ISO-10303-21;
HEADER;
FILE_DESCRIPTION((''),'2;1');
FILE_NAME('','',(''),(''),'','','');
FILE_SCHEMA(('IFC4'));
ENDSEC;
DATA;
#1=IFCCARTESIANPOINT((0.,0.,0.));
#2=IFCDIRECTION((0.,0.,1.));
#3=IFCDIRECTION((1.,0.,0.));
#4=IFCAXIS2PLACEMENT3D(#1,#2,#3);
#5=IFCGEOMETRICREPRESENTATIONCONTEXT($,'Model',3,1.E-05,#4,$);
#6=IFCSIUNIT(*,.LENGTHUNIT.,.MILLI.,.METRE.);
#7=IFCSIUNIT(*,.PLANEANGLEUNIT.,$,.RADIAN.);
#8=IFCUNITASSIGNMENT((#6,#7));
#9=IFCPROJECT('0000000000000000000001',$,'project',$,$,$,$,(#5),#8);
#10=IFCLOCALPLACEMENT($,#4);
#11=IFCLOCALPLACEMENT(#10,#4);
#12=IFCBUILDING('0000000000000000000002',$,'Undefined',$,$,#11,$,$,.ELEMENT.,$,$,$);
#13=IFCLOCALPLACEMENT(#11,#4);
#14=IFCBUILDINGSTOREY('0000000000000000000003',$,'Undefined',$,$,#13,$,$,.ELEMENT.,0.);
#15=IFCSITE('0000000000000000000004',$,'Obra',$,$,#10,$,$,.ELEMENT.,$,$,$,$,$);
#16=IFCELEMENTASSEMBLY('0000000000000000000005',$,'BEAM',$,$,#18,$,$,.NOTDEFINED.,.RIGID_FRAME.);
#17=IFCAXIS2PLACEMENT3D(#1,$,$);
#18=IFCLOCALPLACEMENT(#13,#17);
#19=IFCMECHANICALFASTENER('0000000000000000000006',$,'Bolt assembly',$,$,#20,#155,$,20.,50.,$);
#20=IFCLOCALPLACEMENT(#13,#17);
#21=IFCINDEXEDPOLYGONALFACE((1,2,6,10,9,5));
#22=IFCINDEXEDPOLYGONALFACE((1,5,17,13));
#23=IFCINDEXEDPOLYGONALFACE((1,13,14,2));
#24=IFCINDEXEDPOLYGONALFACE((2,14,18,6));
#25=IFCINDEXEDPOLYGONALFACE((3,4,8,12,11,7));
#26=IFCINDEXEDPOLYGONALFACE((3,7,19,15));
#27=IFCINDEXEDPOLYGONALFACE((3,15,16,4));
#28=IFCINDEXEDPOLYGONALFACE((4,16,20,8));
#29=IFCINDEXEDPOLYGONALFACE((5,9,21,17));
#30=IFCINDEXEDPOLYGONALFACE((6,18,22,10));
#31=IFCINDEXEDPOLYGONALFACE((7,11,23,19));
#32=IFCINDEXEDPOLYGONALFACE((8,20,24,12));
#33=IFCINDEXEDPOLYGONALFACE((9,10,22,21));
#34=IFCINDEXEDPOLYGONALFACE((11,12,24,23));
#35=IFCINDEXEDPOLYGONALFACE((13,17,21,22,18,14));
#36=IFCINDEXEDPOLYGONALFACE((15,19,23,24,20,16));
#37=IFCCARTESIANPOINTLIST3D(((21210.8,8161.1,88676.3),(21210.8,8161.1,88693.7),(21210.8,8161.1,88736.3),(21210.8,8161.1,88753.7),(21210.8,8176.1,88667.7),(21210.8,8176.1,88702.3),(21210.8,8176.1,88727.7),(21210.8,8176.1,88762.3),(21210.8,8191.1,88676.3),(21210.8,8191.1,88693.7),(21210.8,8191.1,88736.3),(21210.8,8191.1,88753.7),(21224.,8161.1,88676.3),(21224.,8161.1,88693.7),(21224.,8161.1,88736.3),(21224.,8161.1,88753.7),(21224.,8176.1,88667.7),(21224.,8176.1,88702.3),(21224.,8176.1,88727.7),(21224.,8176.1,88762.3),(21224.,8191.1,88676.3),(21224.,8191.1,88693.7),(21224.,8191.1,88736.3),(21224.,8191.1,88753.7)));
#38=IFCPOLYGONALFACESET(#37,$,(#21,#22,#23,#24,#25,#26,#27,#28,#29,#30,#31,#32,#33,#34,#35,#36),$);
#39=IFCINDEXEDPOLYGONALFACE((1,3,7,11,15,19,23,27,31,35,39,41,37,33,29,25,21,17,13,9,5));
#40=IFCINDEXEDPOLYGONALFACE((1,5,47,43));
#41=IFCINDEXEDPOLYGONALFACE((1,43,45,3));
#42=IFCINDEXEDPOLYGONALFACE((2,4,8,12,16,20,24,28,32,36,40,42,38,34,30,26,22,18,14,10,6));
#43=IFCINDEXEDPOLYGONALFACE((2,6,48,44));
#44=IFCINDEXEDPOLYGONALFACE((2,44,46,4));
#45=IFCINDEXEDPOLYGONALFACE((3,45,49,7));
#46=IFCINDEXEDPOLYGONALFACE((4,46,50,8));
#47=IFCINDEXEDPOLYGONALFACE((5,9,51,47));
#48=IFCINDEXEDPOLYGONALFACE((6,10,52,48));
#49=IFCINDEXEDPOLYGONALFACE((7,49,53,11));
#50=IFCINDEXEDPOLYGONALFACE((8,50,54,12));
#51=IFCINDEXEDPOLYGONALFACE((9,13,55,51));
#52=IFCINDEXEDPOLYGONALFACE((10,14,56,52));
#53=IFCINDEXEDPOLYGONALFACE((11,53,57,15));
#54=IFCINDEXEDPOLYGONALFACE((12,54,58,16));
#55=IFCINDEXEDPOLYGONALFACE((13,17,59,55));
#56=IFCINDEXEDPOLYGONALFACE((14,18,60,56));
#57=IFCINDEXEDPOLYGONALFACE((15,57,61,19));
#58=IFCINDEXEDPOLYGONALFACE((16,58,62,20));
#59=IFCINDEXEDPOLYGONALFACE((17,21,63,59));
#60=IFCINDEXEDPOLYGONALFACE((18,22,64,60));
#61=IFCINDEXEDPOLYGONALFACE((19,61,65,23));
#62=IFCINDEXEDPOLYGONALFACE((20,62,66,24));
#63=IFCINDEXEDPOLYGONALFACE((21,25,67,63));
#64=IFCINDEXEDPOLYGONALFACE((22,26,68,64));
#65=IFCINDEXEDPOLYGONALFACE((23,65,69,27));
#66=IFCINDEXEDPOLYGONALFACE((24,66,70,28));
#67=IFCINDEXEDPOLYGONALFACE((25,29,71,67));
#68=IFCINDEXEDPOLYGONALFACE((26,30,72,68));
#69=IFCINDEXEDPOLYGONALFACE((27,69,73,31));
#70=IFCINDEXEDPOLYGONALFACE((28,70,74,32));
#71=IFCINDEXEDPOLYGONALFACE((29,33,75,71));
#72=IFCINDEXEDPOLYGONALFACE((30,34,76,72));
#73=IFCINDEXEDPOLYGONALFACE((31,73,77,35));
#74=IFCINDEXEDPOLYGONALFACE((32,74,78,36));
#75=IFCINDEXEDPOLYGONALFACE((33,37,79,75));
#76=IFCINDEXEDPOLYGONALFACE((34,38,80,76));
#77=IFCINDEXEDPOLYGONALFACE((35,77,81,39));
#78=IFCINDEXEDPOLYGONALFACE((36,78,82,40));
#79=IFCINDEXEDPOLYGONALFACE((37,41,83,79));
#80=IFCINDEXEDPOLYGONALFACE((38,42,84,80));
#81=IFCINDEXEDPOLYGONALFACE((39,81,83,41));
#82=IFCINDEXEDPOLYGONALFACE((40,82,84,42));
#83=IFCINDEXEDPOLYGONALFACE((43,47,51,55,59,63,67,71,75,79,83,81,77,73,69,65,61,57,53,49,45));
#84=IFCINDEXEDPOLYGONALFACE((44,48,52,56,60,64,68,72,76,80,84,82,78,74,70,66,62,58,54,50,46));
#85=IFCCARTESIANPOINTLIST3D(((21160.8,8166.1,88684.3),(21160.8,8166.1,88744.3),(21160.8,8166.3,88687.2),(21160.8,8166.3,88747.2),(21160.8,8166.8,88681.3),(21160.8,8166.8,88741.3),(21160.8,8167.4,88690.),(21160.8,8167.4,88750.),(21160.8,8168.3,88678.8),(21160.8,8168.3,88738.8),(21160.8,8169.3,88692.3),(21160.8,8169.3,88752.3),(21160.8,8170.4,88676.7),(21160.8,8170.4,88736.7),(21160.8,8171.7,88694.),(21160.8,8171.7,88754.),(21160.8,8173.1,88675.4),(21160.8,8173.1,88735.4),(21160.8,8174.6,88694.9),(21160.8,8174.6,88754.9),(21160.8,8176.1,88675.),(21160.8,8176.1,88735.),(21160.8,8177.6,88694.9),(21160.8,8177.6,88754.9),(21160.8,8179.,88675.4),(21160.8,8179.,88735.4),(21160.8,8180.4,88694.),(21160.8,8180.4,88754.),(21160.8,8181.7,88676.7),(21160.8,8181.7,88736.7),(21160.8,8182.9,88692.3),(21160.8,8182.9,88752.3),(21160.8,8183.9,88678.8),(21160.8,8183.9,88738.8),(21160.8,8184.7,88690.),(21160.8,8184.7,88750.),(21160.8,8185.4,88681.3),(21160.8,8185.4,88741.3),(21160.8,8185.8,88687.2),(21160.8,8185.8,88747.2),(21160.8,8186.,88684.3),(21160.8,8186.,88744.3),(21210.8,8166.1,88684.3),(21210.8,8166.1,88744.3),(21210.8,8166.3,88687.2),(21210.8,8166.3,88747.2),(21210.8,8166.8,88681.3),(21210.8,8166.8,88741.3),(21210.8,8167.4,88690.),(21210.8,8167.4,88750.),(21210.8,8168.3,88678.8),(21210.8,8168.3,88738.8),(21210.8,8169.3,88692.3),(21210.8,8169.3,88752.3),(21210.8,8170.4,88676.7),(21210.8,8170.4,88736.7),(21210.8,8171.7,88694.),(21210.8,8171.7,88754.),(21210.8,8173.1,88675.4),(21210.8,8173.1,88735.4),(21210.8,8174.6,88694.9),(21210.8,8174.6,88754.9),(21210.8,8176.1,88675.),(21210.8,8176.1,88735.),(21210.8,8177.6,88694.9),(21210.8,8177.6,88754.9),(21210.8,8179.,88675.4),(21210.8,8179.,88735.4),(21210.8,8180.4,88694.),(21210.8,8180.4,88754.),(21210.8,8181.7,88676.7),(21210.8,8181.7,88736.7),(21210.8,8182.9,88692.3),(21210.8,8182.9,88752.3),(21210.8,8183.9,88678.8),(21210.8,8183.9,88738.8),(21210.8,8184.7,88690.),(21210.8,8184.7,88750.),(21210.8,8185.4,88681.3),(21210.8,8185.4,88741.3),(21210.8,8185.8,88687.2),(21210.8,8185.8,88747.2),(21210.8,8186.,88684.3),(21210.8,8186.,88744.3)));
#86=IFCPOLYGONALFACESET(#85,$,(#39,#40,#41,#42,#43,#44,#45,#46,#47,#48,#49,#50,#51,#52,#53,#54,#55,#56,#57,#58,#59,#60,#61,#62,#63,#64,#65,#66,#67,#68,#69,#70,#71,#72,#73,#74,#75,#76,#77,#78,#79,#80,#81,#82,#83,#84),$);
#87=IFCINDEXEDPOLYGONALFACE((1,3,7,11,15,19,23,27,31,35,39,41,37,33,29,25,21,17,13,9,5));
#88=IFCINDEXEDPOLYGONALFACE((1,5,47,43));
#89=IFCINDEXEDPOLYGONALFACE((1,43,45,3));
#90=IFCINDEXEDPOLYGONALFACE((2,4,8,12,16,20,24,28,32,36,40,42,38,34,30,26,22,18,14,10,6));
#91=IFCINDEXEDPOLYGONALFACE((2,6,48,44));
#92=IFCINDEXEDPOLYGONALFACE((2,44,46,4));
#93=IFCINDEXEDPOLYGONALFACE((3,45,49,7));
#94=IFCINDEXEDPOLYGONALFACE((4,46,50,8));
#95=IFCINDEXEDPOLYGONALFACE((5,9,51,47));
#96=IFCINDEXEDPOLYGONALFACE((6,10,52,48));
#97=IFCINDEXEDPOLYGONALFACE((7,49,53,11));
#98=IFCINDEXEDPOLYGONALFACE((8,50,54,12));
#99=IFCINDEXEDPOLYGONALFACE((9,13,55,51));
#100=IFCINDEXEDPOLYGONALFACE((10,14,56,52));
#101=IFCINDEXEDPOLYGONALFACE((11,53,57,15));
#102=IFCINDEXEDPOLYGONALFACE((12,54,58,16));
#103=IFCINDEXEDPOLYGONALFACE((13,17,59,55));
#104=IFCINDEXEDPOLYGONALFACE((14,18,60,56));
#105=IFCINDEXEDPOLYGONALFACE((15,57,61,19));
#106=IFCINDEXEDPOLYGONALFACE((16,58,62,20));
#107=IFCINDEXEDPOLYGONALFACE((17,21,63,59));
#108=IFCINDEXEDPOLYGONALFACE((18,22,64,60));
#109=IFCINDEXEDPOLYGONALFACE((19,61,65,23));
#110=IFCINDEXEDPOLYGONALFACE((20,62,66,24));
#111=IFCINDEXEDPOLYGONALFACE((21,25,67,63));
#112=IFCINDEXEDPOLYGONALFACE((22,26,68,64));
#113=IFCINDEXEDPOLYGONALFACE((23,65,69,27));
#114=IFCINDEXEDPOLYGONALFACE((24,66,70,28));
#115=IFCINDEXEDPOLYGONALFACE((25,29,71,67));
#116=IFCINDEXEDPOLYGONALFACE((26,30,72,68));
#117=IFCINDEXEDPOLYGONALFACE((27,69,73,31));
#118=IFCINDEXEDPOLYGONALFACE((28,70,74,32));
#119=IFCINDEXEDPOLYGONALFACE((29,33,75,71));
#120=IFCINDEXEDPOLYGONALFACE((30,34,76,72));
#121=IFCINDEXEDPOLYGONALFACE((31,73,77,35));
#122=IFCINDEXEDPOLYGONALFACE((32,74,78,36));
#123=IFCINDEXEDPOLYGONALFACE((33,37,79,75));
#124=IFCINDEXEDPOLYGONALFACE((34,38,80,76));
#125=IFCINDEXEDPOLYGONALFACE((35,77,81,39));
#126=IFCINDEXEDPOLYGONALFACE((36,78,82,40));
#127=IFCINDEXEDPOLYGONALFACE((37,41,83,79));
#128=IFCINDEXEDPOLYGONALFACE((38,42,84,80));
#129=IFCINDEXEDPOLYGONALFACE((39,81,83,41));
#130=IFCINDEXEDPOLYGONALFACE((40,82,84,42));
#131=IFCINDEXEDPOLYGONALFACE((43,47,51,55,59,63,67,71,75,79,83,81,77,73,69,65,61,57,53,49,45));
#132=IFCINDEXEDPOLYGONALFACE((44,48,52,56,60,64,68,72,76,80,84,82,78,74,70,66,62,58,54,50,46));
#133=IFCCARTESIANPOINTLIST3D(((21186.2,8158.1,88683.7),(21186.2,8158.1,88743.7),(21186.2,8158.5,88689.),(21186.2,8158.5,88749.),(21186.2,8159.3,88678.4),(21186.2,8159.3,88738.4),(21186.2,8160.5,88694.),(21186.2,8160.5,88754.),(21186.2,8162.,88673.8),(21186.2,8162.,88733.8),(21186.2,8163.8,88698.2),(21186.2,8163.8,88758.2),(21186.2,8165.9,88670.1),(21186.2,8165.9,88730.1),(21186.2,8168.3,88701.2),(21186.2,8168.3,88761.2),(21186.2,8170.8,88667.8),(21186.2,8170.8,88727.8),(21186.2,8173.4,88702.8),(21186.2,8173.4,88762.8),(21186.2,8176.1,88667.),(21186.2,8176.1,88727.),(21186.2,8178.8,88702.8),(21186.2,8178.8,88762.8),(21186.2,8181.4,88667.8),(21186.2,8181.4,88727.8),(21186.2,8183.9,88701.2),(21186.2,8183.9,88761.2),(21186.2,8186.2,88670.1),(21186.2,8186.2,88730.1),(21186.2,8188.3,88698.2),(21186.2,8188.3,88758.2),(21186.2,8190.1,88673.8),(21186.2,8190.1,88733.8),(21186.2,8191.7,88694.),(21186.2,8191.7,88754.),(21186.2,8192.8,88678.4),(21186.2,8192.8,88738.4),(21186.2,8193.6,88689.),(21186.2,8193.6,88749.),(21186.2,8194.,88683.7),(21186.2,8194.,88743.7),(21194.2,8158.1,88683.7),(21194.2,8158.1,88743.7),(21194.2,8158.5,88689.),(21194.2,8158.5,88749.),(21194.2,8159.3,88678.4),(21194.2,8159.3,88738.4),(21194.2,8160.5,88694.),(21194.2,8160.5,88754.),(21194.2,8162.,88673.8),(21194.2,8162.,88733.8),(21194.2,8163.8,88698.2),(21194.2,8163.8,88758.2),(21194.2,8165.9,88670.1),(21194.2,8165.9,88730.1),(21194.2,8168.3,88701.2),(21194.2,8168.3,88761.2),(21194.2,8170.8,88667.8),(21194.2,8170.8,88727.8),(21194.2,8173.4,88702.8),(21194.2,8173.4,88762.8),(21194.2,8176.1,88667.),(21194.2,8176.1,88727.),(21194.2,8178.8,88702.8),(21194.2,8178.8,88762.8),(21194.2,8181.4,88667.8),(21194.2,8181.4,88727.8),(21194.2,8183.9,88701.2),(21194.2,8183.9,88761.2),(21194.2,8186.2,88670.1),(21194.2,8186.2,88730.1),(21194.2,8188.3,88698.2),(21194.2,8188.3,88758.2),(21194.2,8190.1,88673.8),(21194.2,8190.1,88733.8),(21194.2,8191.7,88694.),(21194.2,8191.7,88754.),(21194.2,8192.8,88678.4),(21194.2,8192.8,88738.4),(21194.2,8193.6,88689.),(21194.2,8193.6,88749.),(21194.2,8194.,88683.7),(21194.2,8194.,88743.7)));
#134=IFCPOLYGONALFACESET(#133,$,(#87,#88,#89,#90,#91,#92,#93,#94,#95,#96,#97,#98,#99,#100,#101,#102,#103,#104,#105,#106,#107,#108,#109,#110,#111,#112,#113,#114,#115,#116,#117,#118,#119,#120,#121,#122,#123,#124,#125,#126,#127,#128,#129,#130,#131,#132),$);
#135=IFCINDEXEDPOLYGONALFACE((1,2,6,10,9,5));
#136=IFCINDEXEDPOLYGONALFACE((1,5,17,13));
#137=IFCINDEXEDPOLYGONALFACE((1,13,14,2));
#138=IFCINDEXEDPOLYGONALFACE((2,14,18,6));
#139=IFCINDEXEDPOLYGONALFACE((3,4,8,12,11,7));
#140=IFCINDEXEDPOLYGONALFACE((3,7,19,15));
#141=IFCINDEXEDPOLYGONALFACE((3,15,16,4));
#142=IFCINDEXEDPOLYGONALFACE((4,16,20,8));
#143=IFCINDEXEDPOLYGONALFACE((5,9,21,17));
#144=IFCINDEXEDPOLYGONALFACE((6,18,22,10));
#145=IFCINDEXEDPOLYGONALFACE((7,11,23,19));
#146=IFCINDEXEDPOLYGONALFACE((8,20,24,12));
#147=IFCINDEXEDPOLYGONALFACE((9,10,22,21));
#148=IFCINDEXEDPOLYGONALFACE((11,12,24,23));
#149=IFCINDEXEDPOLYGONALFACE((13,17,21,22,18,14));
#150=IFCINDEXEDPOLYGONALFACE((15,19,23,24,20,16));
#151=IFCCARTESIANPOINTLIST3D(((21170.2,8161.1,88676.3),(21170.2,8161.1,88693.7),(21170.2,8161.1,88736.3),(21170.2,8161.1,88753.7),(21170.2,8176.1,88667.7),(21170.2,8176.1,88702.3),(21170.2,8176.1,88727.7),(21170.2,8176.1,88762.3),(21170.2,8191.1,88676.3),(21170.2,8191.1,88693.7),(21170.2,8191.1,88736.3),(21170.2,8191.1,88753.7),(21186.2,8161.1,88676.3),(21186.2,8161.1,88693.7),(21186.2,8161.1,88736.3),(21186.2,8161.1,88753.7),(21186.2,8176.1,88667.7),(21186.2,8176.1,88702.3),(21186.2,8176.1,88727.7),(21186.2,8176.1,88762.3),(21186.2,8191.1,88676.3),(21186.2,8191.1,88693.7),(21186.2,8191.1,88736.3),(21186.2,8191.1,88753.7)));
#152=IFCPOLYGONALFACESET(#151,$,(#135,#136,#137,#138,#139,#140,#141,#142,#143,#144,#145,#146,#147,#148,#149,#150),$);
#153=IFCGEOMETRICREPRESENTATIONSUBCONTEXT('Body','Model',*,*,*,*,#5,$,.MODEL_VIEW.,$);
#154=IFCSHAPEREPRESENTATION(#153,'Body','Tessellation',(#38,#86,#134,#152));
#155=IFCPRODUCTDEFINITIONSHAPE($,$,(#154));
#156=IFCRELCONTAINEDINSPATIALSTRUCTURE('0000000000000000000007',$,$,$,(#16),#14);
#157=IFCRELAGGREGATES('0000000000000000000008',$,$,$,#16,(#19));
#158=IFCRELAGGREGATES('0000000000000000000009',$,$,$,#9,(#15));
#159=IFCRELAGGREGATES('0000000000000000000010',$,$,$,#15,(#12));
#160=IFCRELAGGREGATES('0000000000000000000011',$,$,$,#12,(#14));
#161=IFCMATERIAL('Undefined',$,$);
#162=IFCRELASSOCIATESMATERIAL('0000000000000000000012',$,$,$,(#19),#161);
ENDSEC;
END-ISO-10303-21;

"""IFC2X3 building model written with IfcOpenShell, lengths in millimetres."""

from ifc_helpers import new_model, si_unit, frame, origin_with_axes, origin_2d_with_axis, place, context, subcontext, project, spatial, polyline, circle, outline, extrude, source, transform, mapped, material, element, aggregate, save


model = new_model("IFC2X3")

# Units and contexts
model_context = context("Model", 3, precision=1e-05, world=origin_with_axes())
body_context = subcontext(model_context, "Body", "Model", "MODEL_VIEW")
ifc_project = project(units=[si_unit("LENGTHUNIT", "METRE", prefix="MILLI"), si_unit("PLANEANGLEUNIT", "RADIAN")], contexts=[model_context])

# Site, building, storey
site_placement = place(None, origin_with_axes())
site = spatial("IfcSite", under=ifc_project, at=site_placement, Name="Obra", CompositionType="ELEMENT")
building_placement = place(site_placement, origin_with_axes())
building = spatial("IfcBuilding", under=site, at=building_placement, Name="Undefined", CompositionType="ELEMENT")
storey_placement = place(building_placement, origin_with_axes())
storey = spatial("IfcBuildingStorey", under=building, at=storey_placement, Name="Undefined", CompositionType="ELEMENT", Elevation=0.0)

# Element assembly, mechanical fastener
ifc_material_1 = material(Name="Undefined")
assembly_1_placement = place(storey_placement, origin_with_axes())
assembly_1 = element("IfcElementAssembly", 1, at=assembly_1_placement, inside=storey, Name="BEAM", AssemblyPlace="NOTDEFINED", PredefinedType="RIGID_FRAME")
shared_shape_1 = source(origin_with_axes(), body_context, "Body", "SweptSolid", [
    extrude(outline(polyline([(17.3, 0.0), (8.7, 15.0), (-8.7, 15.0), (-17.3, 0.0), (-8.7, -15.0), (8.7, -15.0), (17.3, 0.0)])), frame((0.0, -26.5, 0.0), z_axis=(0.0, 1.0, 0.0), x_axis=(1.0, 0.0, 0.0)), (0.0, 0.0, 1.0), 13.2),
    extrude(circle(Radius=10.0, at=origin_2d_with_axis()), frame((0.0, -13.3, 0.0), z_axis=(0.0, 1.0, 0.0), x_axis=(1.0, 0.0, 0.0)), (0.0, 0.0, 1.0), 50.0),
    extrude(circle(Radius=18.0, at=origin_2d_with_axis()), frame((0.0, 3.3, 0.0), z_axis=(0.0, 1.0, 0.0), x_axis=(1.0, 0.0, 0.0)), (0.0, 0.0, 1.0), 8.0),
    extrude(outline(polyline([(17.3, 0.0), (8.7, 15.0), (-8.7, 15.0), (-17.3, 0.0), (-8.7, -15.0), (8.7, -15.0), (17.3, 0.0)])), frame((0.0, 11.3, 0.0), z_axis=(0.0, 1.0, 0.0), x_axis=(1.0, 0.0, 0.0)), (0.0, 0.0, 1.0), 16.0),
])
mechanical_fastener_1_placement = place(assembly_1_placement, frame((21197.5, 8136.1, 88850.0), z_axis=(0.0, 1.0, 0.0), x_axis=(0.0, 0.0, -1.0)))
mechanical_fastener_1 = element("IfcMechanicalFastener", 2, at=mechanical_fastener_1_placement, material=ifc_material_1, Name="Bolt assembly", NominalDiameter=20.0, NominalLength=50.0, context=body_context, shape_type="MappedRepresentation", body=[
    mapped(shared_shape_1, transform((105.0, 0.0, 40.0))),
    mapped(shared_shape_1, transform((165.0, 0.0, 40.0))),
])
aggregate(assembly_1, [mechanical_fastener_1])

save(model, "model.ifc")
